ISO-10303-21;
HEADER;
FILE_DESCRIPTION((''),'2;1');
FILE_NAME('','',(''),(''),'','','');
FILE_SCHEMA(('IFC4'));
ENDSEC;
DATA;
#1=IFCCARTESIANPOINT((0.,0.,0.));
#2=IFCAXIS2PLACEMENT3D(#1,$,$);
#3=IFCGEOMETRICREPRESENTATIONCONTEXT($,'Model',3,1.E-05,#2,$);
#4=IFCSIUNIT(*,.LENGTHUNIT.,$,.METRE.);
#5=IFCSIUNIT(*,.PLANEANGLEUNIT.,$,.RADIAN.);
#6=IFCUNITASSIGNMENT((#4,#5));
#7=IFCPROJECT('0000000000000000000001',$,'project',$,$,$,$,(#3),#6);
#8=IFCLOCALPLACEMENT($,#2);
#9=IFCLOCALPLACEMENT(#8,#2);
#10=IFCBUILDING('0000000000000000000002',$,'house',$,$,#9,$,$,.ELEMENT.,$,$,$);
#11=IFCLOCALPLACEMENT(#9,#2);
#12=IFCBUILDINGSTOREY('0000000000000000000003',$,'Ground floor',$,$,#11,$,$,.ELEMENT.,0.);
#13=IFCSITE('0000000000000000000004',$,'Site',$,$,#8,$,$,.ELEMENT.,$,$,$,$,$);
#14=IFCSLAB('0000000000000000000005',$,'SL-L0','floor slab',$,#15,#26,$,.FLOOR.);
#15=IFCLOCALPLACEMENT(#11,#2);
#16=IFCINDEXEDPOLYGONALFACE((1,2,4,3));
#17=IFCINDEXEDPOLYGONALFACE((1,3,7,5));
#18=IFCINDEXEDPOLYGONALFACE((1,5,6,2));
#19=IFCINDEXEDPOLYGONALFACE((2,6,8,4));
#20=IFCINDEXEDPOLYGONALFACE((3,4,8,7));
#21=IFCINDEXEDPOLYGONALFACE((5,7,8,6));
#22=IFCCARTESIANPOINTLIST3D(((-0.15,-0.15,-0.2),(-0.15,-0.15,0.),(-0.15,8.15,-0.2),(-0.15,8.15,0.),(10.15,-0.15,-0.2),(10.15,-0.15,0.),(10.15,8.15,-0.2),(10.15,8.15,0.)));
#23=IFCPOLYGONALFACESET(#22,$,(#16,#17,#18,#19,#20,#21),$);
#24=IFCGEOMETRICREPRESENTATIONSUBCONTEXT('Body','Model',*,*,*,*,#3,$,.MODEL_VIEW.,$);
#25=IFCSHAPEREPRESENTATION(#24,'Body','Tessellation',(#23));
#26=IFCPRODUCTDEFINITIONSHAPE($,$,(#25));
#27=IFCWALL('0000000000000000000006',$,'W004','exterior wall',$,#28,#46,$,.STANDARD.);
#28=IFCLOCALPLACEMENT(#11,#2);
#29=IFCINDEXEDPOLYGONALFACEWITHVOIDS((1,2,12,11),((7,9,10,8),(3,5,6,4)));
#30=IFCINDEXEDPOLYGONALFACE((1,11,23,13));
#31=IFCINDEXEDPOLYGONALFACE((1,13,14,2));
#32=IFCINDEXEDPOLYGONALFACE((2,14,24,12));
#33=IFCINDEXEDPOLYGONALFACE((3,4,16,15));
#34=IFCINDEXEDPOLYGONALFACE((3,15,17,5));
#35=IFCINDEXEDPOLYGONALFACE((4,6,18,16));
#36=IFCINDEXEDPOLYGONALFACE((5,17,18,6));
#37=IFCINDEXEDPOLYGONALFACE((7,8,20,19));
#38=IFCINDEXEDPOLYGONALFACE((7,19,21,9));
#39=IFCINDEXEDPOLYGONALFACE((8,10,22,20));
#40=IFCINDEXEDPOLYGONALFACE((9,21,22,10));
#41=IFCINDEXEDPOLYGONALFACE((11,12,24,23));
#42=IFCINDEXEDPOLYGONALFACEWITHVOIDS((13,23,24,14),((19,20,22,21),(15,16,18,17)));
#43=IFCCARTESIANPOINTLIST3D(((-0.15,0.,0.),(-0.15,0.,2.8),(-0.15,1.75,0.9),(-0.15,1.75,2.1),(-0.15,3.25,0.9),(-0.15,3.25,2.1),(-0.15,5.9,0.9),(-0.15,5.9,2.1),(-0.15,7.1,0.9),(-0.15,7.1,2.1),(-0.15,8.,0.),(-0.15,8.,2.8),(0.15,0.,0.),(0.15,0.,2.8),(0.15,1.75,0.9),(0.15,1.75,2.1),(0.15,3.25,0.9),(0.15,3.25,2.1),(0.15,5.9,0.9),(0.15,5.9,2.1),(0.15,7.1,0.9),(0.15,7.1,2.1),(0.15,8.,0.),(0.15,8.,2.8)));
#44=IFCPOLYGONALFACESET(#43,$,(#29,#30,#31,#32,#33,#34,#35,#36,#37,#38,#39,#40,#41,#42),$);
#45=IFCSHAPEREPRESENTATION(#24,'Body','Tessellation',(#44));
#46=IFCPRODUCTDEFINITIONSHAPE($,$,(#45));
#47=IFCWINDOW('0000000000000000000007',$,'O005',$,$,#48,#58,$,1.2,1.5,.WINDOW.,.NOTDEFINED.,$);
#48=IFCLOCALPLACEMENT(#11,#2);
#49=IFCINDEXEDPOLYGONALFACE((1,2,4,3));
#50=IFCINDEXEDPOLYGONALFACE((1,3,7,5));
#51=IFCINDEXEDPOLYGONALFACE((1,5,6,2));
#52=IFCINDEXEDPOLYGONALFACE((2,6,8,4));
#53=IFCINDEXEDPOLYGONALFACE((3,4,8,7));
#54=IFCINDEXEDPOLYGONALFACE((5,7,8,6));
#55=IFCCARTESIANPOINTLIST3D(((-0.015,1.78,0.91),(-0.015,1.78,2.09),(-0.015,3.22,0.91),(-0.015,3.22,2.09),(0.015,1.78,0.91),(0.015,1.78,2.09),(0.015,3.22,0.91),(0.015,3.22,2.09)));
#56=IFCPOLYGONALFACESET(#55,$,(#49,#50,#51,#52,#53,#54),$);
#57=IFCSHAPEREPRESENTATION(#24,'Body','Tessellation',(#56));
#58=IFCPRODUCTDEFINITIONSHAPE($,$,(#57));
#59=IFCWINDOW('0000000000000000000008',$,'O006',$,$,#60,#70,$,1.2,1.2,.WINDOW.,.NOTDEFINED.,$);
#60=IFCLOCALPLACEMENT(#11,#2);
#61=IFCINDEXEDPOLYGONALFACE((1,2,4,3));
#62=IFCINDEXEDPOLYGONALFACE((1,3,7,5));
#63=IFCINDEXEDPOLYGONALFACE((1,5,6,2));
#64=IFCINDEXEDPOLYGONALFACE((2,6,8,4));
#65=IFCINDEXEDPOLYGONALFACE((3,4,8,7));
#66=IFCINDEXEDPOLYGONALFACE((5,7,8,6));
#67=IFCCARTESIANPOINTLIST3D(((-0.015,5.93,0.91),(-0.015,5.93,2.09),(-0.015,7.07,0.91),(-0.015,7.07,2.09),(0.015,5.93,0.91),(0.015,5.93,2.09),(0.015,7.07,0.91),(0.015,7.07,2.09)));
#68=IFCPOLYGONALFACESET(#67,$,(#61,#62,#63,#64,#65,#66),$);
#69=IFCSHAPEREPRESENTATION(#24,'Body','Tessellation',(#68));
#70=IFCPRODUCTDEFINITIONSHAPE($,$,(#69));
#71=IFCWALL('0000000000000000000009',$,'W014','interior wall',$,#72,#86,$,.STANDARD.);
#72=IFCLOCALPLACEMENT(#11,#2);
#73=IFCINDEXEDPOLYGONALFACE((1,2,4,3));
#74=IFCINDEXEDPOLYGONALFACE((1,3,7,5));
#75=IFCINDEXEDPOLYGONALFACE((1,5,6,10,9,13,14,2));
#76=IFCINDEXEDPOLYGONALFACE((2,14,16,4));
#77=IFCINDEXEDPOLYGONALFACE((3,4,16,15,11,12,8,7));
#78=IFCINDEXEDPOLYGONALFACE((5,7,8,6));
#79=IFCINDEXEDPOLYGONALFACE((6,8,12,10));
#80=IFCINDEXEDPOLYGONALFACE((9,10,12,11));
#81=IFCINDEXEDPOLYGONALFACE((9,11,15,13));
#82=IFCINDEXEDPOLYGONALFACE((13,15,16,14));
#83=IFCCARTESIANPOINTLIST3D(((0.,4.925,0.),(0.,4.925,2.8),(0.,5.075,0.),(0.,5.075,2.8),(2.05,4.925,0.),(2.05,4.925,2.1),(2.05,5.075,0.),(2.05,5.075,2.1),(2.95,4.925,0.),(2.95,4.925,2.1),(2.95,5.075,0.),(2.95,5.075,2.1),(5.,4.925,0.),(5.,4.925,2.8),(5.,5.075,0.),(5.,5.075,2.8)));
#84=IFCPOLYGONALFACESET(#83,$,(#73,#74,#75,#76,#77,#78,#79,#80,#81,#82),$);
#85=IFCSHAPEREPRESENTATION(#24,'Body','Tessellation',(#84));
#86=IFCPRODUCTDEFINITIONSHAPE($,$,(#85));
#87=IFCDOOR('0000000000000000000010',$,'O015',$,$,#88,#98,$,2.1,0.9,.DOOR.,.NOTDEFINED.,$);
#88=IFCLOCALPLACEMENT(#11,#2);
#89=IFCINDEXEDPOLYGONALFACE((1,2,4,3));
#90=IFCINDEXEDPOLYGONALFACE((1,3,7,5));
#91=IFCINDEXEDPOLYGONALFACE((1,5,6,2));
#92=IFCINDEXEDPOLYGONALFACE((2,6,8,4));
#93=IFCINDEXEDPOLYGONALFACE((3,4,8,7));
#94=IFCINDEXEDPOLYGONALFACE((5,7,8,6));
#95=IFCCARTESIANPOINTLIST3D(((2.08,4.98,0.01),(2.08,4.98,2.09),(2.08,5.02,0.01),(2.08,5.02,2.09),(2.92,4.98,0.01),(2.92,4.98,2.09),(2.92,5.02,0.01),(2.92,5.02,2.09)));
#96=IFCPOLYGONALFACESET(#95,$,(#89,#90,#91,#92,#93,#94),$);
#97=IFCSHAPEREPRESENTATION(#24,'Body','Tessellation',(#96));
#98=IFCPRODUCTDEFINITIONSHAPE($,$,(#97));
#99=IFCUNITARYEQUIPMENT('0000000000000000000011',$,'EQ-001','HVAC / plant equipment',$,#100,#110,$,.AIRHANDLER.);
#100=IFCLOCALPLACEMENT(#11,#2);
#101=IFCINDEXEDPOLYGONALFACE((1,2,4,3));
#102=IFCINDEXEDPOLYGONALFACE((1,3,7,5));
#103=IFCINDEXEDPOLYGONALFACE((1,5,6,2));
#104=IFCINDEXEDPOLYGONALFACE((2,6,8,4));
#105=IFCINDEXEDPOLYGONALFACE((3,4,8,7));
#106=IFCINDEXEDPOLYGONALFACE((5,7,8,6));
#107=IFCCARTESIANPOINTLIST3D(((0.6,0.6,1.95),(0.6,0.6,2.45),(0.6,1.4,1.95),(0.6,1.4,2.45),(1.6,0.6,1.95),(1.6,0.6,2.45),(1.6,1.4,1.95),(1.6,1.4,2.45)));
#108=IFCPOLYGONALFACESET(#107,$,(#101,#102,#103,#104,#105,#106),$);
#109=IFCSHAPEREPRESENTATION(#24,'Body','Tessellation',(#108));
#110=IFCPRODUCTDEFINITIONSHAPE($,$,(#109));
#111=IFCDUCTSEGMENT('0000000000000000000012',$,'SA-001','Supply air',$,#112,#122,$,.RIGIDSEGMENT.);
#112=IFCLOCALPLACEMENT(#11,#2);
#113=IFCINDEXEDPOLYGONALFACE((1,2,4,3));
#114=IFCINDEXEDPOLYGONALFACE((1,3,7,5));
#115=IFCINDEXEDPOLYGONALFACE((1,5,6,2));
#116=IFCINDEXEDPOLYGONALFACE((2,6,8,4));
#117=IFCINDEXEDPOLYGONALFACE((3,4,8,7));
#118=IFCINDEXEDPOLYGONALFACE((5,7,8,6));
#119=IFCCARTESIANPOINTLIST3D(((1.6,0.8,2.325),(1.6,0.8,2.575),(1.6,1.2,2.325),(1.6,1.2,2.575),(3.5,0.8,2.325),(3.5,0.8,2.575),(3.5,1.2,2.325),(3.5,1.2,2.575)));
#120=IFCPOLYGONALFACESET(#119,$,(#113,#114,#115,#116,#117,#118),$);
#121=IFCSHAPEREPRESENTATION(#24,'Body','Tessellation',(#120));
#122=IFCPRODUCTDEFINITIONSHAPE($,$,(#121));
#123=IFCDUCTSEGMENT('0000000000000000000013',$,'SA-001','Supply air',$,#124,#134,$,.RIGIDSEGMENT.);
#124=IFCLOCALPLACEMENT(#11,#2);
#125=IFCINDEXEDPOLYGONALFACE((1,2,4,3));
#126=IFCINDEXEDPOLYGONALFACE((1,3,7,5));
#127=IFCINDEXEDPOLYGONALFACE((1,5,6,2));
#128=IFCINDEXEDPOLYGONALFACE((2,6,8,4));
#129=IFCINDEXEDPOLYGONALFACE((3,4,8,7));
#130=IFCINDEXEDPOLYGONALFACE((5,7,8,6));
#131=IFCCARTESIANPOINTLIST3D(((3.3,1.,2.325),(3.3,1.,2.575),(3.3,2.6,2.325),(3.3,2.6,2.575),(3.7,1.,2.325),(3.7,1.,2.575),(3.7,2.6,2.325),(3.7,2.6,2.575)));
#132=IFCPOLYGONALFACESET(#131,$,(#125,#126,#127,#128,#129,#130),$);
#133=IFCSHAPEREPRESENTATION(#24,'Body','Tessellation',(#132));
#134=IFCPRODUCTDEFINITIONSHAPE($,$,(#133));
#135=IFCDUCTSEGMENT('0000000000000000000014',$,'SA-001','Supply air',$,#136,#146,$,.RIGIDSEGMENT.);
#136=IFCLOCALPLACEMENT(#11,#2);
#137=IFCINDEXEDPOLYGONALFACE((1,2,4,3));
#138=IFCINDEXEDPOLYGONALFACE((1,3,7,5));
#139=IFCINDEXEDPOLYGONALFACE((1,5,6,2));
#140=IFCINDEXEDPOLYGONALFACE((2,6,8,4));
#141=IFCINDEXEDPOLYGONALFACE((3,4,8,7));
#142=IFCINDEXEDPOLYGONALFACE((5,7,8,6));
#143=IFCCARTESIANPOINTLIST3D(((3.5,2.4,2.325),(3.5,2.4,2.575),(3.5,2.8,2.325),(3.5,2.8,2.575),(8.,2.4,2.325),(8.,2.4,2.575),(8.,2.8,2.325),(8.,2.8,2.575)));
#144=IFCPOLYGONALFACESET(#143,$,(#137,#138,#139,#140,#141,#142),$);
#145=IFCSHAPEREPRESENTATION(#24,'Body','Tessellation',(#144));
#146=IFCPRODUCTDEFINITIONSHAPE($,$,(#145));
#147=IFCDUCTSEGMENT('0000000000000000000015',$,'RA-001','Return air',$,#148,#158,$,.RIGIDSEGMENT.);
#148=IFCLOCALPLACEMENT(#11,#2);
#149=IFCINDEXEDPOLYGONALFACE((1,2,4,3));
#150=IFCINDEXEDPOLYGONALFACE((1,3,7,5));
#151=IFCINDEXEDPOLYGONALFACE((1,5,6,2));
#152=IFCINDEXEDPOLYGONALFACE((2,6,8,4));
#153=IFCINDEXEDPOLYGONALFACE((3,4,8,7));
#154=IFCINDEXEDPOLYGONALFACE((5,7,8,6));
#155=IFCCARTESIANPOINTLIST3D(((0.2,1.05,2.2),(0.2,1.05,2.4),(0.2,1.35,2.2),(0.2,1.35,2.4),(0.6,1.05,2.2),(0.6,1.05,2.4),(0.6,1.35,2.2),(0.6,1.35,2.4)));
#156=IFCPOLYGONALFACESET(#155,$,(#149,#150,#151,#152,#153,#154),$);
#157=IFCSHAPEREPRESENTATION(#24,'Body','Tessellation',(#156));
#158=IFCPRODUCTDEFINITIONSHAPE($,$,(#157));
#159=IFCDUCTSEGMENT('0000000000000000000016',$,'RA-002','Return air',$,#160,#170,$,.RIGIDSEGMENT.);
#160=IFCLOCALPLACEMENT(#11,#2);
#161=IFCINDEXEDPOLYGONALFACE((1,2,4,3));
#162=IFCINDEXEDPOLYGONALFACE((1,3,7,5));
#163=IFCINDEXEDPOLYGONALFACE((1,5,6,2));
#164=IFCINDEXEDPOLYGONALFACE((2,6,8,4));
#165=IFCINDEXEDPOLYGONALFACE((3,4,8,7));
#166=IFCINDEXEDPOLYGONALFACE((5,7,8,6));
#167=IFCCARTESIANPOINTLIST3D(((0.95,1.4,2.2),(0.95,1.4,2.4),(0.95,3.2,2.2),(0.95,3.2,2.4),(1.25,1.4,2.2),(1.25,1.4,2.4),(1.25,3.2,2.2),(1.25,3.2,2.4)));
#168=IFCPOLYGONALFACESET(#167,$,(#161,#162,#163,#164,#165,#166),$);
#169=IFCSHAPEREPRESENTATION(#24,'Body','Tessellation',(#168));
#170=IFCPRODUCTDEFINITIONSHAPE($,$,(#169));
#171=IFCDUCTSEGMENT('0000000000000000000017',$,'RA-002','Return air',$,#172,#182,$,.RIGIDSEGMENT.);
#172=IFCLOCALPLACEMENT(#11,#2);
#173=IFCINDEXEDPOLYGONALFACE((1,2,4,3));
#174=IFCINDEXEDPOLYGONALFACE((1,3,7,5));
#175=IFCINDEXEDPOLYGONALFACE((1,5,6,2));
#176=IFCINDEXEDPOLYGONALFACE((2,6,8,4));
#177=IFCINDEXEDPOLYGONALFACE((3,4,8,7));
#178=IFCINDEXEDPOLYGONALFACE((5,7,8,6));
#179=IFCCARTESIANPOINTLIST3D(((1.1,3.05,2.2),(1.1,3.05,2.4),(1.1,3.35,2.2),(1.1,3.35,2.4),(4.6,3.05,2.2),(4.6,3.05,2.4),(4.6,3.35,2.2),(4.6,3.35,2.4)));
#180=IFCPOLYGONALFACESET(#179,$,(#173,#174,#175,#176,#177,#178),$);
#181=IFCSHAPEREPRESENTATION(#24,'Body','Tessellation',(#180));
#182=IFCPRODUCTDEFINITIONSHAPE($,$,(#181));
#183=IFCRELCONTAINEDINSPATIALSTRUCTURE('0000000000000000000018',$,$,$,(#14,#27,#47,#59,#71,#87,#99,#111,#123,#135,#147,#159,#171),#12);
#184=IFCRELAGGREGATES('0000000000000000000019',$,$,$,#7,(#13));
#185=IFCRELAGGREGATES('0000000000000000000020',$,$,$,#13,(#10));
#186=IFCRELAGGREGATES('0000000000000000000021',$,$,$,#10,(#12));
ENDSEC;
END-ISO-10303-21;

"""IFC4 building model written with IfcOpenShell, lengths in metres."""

from ifc_helpers import new_model, si_unit, frame, origin, origin_2d, place, context, subcontext, project, spatial, polyline, rectangle, outline, extrude, element, fill, save


model = new_model("IFC4")

# Units and contexts
model_context = context("Model", 3, precision=1e-05, world=origin())
body_context = subcontext(model_context, "Body", "Model", "MODEL_VIEW")
ifc_project = project(units=[si_unit("LENGTHUNIT", "METRE"), si_unit("PLANEANGLEUNIT", "RADIAN")], contexts=[model_context])

# Site, building, storey
site_placement = place(None, origin())
site = spatial("IfcSite", under=ifc_project, at=site_placement, Name="Site", CompositionType="ELEMENT")
building_placement = place(site_placement, origin())
building = spatial("IfcBuilding", under=site, at=building_placement, Name="house", CompositionType="ELEMENT")
storey_placement = place(building_placement, origin())
storey = spatial("IfcBuildingStorey", under=building, at=storey_placement, Name="Ground floor", CompositionType="ELEMENT", Elevation=0.0)

# Slab
slab_placement = place(storey_placement, frame((0.0, 0.0, -0.2)))
element("IfcSlab", 1, at=slab_placement, inside=storey, Name="SL-L0", Description="floor slab", PredefinedType="FLOOR", context=body_context, shape_type="SweptSolid", body=[
    extrude(outline(polyline([(-0.15, 8.15), (10.15, 8.15), (10.15, -0.15), (-0.15, -0.15), (-0.15, 8.15)])), origin(), (0.0, 0.0, 1.0), 0.2),
])

# Wall, openings, windows
wall_1_placement = place(storey_placement, frame((0.0, 4.0, 0.0), z_axis=(0.0, 0.0, 1.0), x_axis=(0.0, 1.0, 0.0)))
wall_1 = element("IfcWall", 2, at=wall_1_placement, inside=storey, Name="W004", Description="exterior wall", PredefinedType="STANDARD", context=body_context, shape_type="SweptSolid", body=[
    extrude(rectangle(XDim=8.0, YDim=0.3, at=origin_2d()), origin(), (0.0, 0.0, 1.0), 2.8),
])
opening_1_placement = place(wall_1_placement, frame((-1.5, 0.0, 0.9)))
opening_1 = element("IfcOpeningElement", 3, at=opening_1_placement, cuts=wall_1, PredefinedType="OPENING", context=body_context, shape_type="SweptSolid", body=[
    extrude(rectangle(XDim=1.5, YDim=0.36, at=origin_2d()), origin(), (0.0, 0.0, 1.0), 1.2),
])
opening_2_placement = place(wall_1_placement, frame((2.5, 0.0, 0.9)))
opening_2 = element("IfcOpeningElement", 4, at=opening_2_placement, cuts=wall_1, PredefinedType="OPENING", context=body_context, shape_type="SweptSolid", body=[
    extrude(rectangle(XDim=1.2, YDim=0.36, at=origin_2d()), origin(), (0.0, 0.0, 1.0), 1.2),
])
window_1_placement = place(wall_1_placement, frame((-1.5, 0.0, 0.9)))
window_1 = element("IfcWindow", 5, at=window_1_placement, inside=storey, Name="O005", OverallHeight=1.2, OverallWidth=1.5, PartitioningType="NOTDEFINED", PredefinedType="WINDOW", context=body_context, shape_type="SweptSolid", body=[
    extrude(rectangle(XDim=1.44, YDim=0.03, at=origin_2d()), frame((0.0, 0.0, 0.01)), (0.0, 0.0, 1.0), 1.18),
])
fill(opening_1, window_1)
window_2_placement = place(wall_1_placement, frame((2.5, 0.0, 0.9)))
window_2 = element("IfcWindow", 6, at=window_2_placement, inside=storey, Name="O006", OverallHeight=1.2, OverallWidth=1.2, PartitioningType="NOTDEFINED", PredefinedType="WINDOW", context=body_context, shape_type="SweptSolid", body=[
    extrude(rectangle(XDim=1.14, YDim=0.03, at=origin_2d()), frame((0.0, 0.0, 0.01)), (0.0, 0.0, 1.0), 1.18),
])
fill(opening_2, window_2)

# Wall, opening, door
wall_2_placement = place(storey_placement, frame((2.5, 5.0, 0.0), z_axis=(0.0, 0.0, 1.0), x_axis=(1.0, 0.0, 0.0)))
wall_2 = element("IfcWall", 7, at=wall_2_placement, inside=storey, Name="W014", Description="interior wall", PredefinedType="STANDARD", context=body_context, shape_type="SweptSolid", body=[
    extrude(rectangle(XDim=5.0, YDim=0.15, at=origin_2d()), origin(), (0.0, 0.0, 1.0), 2.8),
])
opening_3_placement = place(wall_2_placement, origin())
opening_3 = element("IfcOpeningElement", 8, at=opening_3_placement, cuts=wall_2, PredefinedType="OPENING", context=body_context, shape_type="SweptSolid", body=[
    extrude(rectangle(XDim=0.9, YDim=0.18, at=origin_2d()), origin(), (0.0, 0.0, 1.0), 2.1),
])
door_placement = place(wall_2_placement, origin())
door = element("IfcDoor", 9, at=door_placement, inside=storey, Name="O015", OperationType="NOTDEFINED", OverallHeight=2.1, OverallWidth=0.9, PredefinedType="DOOR", context=body_context, shape_type="SweptSolid", body=[
    extrude(rectangle(XDim=0.84, YDim=0.04, at=origin_2d()), frame((0.0, 0.0, 0.01)), (0.0, 0.0, 1.0), 2.08),
])
fill(opening_3, door)

# Unitary equipment
unitary_equipment_placement = place(storey_placement, frame((1.1, 1.0, 1.95), z_axis=(0.0, 0.0, 1.0), x_axis=(1.0, 0.0, 0.0)))
element("IfcUnitaryEquipment", 10, at=unitary_equipment_placement, inside=storey, Name="EQ-001", Description="HVAC / plant equipment", PredefinedType="AIRHANDLER", context=body_context, shape_type="SweptSolid", body=[
    extrude(rectangle(XDim=1.0, YDim=0.8, at=origin_2d()), origin(), (0.0, 0.0, 1.0), 0.5),
])

# Duct segments
duct_segment_1_placement = place(storey_placement, frame((1.6, 1.0, 2.45), z_axis=(1.0, 0.0, 0.0), x_axis=(0.0, 1.0, 0.0)))
element("IfcDuctSegment", 11, at=duct_segment_1_placement, inside=storey, Name="SA-001", Description="Supply air", PredefinedType="RIGIDSEGMENT", context=body_context, shape_type="SweptSolid", body=[
    extrude(rectangle(XDim=0.4, YDim=0.25, at=origin_2d()), origin(), (0.0, 0.0, 1.0), 1.9),
])
duct_segment_2_placement = place(storey_placement, frame((3.5, 1.0, 2.45), z_axis=(0.0, 1.0, 0.0), x_axis=(-1.0, 0.0, 0.0)))
element("IfcDuctSegment", 12, at=duct_segment_2_placement, inside=storey, Name="SA-001", Description="Supply air", PredefinedType="RIGIDSEGMENT", context=body_context, shape_type="SweptSolid", body=[
    extrude(rectangle(XDim=0.4, YDim=0.25, at=origin_2d()), origin(), (0.0, 0.0, 1.0), 1.6),
])
duct_segment_3_placement = place(storey_placement, frame((3.5, 2.6, 2.45), z_axis=(1.0, 0.0, 0.0), x_axis=(0.0, 1.0, 0.0)))
element("IfcDuctSegment", 13, at=duct_segment_3_placement, inside=storey, Name="SA-001", Description="Supply air", PredefinedType="RIGIDSEGMENT", context=body_context, shape_type="SweptSolid", body=[
    extrude(rectangle(XDim=0.4, YDim=0.25, at=origin_2d()), origin(), (0.0, 0.0, 1.0), 4.5),
])
duct_segment_4_placement = place(storey_placement, frame((0.6, 1.2, 2.3), z_axis=(-1.0, 0.0, 0.0), x_axis=(0.0, -1.0, 0.0)))
element("IfcDuctSegment", 14, at=duct_segment_4_placement, inside=storey, Name="RA-001", Description="Return air", PredefinedType="RIGIDSEGMENT", context=body_context, shape_type="SweptSolid", body=[
    extrude(rectangle(XDim=0.3, YDim=0.2, at=origin_2d()), origin(), (0.0, 0.0, 1.0), 0.4),
])
duct_segment_5_placement = place(storey_placement, frame((1.1, 1.4, 2.3), z_axis=(0.0, 1.0, 0.0), x_axis=(-1.0, 0.0, 0.0)))
element("IfcDuctSegment", 15, at=duct_segment_5_placement, inside=storey, Name="RA-002", Description="Return air", PredefinedType="RIGIDSEGMENT", context=body_context, shape_type="SweptSolid", body=[
    extrude(rectangle(XDim=0.3, YDim=0.2, at=origin_2d()), origin(), (0.0, 0.0, 1.0), 1.8),
])
duct_segment_6_placement = place(storey_placement, frame((1.1, 3.2, 2.3), z_axis=(1.0, 0.0, 0.0), x_axis=(0.0, 1.0, 0.0)))
element("IfcDuctSegment", 16, at=duct_segment_6_placement, inside=storey, Name="RA-002", Description="Return air", PredefinedType="RIGIDSEGMENT", context=body_context, shape_type="SweptSolid", body=[
    extrude(rectangle(XDim=0.3, YDim=0.2, at=origin_2d()), origin(), (0.0, 0.0, 1.0), 3.5),
])

save(model, "model.ifc")
